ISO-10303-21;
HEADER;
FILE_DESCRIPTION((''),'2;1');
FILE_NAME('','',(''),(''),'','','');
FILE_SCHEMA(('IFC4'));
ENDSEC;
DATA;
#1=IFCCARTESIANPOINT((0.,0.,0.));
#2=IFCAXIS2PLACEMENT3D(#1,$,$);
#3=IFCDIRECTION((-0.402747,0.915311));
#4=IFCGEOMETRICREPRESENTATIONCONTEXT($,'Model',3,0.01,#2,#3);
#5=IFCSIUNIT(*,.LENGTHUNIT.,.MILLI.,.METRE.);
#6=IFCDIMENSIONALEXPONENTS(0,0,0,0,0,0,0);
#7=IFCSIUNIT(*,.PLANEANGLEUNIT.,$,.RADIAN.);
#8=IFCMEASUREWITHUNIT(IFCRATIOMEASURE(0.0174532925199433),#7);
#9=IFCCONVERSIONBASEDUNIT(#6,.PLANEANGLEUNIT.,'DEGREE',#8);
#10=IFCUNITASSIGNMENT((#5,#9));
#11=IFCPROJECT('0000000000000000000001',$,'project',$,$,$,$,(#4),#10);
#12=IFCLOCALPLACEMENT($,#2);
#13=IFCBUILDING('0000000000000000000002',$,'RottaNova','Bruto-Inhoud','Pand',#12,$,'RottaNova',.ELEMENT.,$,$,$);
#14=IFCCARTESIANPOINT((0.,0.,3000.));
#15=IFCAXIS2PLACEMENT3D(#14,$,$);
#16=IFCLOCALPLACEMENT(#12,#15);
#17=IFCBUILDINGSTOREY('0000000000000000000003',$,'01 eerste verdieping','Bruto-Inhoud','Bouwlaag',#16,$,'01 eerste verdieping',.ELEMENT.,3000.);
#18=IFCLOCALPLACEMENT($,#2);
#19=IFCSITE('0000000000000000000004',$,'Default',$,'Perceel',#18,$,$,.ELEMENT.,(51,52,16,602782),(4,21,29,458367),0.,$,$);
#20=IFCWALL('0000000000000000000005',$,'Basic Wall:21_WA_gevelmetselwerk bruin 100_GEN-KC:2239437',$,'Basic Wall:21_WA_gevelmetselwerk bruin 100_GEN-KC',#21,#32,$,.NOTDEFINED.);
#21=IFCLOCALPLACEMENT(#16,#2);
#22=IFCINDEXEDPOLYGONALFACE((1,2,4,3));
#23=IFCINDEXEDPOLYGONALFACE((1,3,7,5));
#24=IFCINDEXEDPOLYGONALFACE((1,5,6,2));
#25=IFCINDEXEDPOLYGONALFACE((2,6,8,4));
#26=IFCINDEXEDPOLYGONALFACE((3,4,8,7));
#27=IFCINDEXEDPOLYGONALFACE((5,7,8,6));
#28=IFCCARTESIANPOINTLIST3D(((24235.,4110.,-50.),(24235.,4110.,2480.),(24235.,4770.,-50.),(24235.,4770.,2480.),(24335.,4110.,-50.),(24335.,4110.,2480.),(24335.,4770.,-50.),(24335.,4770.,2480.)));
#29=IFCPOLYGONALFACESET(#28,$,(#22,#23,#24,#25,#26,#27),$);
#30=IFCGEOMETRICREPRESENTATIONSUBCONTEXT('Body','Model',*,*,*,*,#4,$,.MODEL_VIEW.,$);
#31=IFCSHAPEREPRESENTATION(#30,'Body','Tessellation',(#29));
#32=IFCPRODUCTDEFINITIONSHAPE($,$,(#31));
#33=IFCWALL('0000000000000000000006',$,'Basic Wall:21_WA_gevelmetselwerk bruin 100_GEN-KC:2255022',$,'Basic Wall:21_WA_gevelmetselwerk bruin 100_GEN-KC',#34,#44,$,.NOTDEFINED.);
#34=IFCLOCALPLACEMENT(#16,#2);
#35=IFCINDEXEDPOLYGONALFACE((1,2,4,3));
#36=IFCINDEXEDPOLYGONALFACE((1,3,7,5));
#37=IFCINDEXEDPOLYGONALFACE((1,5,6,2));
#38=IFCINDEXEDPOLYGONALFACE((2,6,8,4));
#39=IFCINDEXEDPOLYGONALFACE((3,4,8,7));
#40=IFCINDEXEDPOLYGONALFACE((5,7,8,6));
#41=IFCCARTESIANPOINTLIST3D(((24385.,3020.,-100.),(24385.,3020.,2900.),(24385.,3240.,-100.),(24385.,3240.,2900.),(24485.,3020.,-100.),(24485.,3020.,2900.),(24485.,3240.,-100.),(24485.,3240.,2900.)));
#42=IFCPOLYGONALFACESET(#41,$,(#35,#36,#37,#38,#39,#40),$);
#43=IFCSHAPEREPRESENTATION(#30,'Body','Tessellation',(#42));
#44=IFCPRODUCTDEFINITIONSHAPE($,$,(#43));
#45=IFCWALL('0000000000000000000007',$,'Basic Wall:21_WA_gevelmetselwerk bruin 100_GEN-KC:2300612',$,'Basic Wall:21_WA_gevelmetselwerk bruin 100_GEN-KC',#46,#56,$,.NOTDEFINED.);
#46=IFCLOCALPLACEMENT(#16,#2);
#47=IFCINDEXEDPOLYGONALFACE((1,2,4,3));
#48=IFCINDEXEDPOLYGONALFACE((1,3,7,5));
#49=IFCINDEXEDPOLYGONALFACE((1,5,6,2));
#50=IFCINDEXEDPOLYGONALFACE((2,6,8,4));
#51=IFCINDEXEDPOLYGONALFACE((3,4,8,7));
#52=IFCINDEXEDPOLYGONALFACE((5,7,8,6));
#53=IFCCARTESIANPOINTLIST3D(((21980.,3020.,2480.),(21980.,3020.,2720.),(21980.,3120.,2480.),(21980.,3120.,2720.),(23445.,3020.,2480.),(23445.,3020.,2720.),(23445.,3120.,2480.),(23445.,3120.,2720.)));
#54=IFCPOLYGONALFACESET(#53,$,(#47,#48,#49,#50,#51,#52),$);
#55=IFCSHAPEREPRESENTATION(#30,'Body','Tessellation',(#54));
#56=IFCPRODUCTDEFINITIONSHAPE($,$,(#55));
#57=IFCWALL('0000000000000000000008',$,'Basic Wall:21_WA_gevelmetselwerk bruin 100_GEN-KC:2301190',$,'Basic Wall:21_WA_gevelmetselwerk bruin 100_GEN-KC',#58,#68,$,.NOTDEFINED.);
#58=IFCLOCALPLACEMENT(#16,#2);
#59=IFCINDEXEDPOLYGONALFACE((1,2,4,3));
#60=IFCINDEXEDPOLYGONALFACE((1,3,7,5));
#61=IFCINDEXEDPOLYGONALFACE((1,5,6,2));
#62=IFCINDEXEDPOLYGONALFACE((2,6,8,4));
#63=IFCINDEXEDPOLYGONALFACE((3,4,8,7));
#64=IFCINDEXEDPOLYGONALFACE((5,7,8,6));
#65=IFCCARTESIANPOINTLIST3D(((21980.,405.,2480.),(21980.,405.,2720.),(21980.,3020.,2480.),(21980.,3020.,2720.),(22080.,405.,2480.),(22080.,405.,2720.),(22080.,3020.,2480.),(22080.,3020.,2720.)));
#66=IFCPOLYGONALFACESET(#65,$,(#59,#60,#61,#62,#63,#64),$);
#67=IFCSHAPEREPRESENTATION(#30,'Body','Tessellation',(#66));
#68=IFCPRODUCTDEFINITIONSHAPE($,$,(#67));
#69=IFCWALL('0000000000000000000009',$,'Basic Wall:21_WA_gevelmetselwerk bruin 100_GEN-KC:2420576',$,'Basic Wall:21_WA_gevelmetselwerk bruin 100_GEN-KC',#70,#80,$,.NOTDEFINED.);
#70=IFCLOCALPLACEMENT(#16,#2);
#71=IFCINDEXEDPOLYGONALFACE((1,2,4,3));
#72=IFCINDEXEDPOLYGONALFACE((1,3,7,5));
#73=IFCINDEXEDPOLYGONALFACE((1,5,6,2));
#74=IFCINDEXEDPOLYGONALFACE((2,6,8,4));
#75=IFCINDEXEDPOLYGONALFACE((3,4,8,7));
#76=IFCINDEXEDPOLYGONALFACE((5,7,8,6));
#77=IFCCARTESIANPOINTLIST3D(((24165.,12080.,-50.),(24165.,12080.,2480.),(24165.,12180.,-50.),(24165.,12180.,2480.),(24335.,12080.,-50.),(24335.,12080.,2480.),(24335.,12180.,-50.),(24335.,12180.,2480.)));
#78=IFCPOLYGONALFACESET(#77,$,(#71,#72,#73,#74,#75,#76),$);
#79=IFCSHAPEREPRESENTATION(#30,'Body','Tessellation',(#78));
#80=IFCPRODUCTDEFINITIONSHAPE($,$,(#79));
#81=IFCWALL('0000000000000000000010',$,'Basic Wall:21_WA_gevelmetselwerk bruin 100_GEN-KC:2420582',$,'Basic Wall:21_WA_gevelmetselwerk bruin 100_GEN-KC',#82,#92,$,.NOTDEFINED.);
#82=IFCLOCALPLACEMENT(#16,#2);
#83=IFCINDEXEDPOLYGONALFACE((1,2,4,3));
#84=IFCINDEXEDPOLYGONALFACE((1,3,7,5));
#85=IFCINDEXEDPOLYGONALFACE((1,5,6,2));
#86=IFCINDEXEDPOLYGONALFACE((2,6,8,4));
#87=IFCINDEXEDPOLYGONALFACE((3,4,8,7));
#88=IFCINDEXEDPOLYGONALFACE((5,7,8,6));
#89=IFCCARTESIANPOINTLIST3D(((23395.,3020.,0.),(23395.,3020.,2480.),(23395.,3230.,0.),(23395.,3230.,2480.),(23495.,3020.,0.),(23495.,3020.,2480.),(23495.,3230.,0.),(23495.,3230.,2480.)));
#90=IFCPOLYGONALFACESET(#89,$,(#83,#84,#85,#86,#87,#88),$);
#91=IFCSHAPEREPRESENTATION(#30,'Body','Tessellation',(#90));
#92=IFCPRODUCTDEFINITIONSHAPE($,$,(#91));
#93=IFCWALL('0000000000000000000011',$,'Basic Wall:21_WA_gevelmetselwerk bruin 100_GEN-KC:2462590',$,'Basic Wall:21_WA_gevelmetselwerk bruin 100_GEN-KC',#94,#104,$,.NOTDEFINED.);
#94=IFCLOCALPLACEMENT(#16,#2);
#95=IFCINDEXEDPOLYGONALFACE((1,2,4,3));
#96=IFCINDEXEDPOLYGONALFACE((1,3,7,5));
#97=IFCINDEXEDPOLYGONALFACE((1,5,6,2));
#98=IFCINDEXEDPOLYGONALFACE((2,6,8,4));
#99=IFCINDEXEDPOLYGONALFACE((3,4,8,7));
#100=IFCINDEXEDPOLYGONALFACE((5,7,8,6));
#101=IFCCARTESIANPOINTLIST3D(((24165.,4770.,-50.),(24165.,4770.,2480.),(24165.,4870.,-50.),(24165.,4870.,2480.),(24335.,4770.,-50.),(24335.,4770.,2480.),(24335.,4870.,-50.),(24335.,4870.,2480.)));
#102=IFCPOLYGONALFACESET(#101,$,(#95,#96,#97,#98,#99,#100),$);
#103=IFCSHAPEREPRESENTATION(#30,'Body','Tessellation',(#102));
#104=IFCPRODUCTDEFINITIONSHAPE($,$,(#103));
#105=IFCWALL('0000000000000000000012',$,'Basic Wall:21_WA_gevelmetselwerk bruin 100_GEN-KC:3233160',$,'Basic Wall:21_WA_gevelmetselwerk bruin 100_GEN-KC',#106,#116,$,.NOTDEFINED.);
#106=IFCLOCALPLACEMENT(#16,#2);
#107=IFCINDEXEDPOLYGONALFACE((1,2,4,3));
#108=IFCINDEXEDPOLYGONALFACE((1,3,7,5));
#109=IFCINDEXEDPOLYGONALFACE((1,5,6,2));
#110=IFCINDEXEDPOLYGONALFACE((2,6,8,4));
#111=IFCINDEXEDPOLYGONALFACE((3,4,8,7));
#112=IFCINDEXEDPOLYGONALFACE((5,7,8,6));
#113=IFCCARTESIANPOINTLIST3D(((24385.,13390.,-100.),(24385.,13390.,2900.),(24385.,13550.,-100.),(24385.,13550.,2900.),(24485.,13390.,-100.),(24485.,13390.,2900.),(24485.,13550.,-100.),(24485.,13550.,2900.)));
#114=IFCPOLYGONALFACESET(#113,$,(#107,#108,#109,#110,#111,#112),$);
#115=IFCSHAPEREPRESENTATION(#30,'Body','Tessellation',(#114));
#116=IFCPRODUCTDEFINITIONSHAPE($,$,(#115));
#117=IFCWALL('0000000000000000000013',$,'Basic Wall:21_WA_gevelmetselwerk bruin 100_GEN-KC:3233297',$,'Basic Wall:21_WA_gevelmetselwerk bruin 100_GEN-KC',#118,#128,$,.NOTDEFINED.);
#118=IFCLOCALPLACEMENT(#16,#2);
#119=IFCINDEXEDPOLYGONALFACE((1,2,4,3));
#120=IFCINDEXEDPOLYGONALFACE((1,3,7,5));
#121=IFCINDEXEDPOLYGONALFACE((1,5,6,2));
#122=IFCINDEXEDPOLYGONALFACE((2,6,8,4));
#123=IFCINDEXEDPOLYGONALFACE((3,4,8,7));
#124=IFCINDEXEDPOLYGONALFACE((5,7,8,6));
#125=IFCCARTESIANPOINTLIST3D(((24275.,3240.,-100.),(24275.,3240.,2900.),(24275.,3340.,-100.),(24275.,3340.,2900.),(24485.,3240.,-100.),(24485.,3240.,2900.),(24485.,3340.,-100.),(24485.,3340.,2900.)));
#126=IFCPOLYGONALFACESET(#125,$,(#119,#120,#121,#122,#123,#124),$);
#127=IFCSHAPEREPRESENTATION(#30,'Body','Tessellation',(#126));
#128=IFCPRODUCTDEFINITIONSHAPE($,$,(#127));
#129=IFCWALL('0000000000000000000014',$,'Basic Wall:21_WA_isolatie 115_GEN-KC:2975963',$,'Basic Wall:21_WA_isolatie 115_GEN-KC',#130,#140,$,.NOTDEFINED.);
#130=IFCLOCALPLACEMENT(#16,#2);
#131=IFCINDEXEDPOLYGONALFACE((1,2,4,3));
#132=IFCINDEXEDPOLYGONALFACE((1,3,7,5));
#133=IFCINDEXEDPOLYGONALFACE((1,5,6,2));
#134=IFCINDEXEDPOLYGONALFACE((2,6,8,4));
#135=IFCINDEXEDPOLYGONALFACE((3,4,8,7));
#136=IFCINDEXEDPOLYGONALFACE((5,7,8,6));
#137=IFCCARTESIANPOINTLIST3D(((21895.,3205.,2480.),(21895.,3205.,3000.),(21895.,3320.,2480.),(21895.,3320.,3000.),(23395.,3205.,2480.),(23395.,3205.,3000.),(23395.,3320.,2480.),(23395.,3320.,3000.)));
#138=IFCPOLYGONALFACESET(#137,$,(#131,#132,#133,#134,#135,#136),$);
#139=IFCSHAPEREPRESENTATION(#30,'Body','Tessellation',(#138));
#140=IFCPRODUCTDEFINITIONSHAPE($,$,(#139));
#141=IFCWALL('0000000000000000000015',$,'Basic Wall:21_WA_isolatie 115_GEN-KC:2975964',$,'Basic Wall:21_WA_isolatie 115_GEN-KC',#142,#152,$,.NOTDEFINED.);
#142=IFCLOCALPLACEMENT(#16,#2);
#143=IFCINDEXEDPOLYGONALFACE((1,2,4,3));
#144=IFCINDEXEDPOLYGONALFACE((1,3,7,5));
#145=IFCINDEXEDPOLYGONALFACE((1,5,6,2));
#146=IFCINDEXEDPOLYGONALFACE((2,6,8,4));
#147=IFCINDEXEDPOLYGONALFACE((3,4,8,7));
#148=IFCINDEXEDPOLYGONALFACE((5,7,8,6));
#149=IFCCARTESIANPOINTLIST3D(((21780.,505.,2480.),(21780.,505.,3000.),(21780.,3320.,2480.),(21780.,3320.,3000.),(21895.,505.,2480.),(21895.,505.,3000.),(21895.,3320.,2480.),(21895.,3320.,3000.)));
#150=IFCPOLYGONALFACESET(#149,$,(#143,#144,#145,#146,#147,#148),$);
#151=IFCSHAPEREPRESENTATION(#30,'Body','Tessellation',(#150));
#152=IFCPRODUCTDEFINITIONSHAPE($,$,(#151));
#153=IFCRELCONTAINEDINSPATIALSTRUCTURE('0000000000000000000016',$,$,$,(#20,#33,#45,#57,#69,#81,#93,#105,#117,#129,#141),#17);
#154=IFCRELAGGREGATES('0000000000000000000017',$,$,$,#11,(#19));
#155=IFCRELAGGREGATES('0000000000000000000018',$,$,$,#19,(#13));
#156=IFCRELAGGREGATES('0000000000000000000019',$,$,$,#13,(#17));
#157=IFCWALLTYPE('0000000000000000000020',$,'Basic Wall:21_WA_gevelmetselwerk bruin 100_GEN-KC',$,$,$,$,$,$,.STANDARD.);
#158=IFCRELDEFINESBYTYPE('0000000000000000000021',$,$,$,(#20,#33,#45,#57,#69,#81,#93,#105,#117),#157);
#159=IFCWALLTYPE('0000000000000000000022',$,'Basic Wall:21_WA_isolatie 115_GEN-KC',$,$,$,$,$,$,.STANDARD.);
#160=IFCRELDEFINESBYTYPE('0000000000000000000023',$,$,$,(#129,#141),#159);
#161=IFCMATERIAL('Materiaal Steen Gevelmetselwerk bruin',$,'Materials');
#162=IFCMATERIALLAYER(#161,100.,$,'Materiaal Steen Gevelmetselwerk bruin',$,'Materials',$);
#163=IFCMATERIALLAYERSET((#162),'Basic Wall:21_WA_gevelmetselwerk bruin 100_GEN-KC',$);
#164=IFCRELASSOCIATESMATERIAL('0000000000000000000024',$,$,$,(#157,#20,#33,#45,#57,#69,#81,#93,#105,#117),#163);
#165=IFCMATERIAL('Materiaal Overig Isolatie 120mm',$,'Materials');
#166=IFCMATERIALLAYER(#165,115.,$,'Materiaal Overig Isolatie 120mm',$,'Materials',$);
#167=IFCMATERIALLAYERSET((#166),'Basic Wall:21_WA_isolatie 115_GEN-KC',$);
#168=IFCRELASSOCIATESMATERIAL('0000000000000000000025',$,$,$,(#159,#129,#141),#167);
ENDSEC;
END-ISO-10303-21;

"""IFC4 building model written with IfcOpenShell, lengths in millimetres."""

from ifc_helpers import new_model, entity, si_unit, converted_unit, direction, frame, frame_2d, origin, place, context, subcontext, project, spatial, rectangle, extrude, material, layer, layer_set, type_object, element, save


model = new_model("IFC4")

# Units and contexts
model_context = context("Model", 3, precision=0.01, world=origin(), true_north=direction((-0.402747, 0.915311)))
body_context = subcontext(model_context, "Body", "Model", "MODEL_VIEW")
ifc_project = project(units=[si_unit("LENGTHUNIT", "METRE", prefix="MILLI"), converted_unit("PLANEANGLEUNIT", "DEGREE", entity("IfcRatioMeasure", 0.0174532925199433), si_unit("PLANEANGLEUNIT", "RADIAN"), dimensions=[0, 0, 0, 0, 0, 0, 0])], contexts=[model_context])

# Site, building, storey
site_placement = place(None, origin())
site = spatial("IfcSite", under=ifc_project, at=site_placement, Name="Default", ObjectType="Perceel", CompositionType="ELEMENT", RefLatitude=(51, 52, 16, 602782), RefLongitude=(4, 21, 29, 458367), RefElevation=0.0)
building_placement = place(None, origin())
building = spatial("IfcBuilding", under=site, at=building_placement, Name="RottaNova", Description="Bruto-Inhoud", ObjectType="Pand", LongName="RottaNova", CompositionType="ELEMENT")
storey_placement = place(building_placement, frame((0.0, 0.0, 3000.0)))
storey = spatial("IfcBuildingStorey", under=building, at=storey_placement, Name="01 eerste verdieping", Description="Bruto-Inhoud", ObjectType="Bouwlaag", LongName="01 eerste verdieping", CompositionType="ELEMENT", Elevation=3000.0)

# Walls
ifc_material_1 = material(Name="Materiaal Steen Gevelmetselwerk bruin", Category="Materials")
ifc_layer_1 = layer(ifc_material_1, 100.0, Name="Materiaal Steen Gevelmetselwerk bruin", Category="Materials")
ifc_layer_set_1 = layer_set([ifc_layer_1], Name="Basic Wall:21_WA_gevelmetselwerk bruin 100_GEN-KC")
wall_type_1 = type_object("IfcWallType", Name="Basic Wall:21_WA_gevelmetselwerk bruin 100_GEN-KC", PredefinedType="STANDARD", material=ifc_layer_set_1)
wall_1_placement = place(storey_placement, frame((24285.0, 4110.0, -50.0), z_axis=(0.0, 0.0, 1.0), x_axis=(0.0, 1.0, 0.0)))
element("IfcWall", 1, at=wall_1_placement, inside=storey, type_object=wall_type_1, material=ifc_layer_set_1, Name="Basic Wall:21_WA_gevelmetselwerk bruin 100_GEN-KC:2239437", ObjectType="Basic Wall:21_WA_gevelmetselwerk bruin 100_GEN-KC", PredefinedType="NOTDEFINED", context=body_context, shape_type="SweptSolid", body=[
    extrude(rectangle(XDim=660.0, YDim=100.0, at=frame_2d((330.0, 0.0), x_axis=(-1.0, 0.0))), origin(), (0.0, 0.0, 1.0), 2530.0),
])
wall_2_placement = place(storey_placement, frame((24435.0, 3240.0, -100.0), z_axis=(0.0, 0.0, 1.0), x_axis=(0.0, -1.0, 0.0)))
element("IfcWall", 2, at=wall_2_placement, inside=storey, type_object=wall_type_1, material=ifc_layer_set_1, Name="Basic Wall:21_WA_gevelmetselwerk bruin 100_GEN-KC:2255022", ObjectType="Basic Wall:21_WA_gevelmetselwerk bruin 100_GEN-KC", PredefinedType="NOTDEFINED", context=body_context, shape_type="SweptSolid", body=[
    extrude(rectangle(XDim=220.0, YDim=100.0, at=frame_2d((110.0, 0.0), x_axis=(-1.0, 0.0))), origin(), (0.0, 0.0, 1.0), 3000.0),
])
wall_3_placement = place(storey_placement, frame((23445.0, 3070.0, 2480.0), z_axis=(0.0, 0.0, 1.0), x_axis=(-1.0, 0.0, 0.0)))
element("IfcWall", 3, at=wall_3_placement, inside=storey, type_object=wall_type_1, material=ifc_layer_set_1, Name="Basic Wall:21_WA_gevelmetselwerk bruin 100_GEN-KC:2300612", ObjectType="Basic Wall:21_WA_gevelmetselwerk bruin 100_GEN-KC", PredefinedType="NOTDEFINED", context=body_context, shape_type="SweptSolid", body=[
    extrude(rectangle(XDim=1465.0, YDim=100.0, at=frame_2d((732.5, 0.0), x_axis=(-1.0, 0.0))), origin(), (0.0, 0.0, 1.0), 240.0),
])
wall_4_placement = place(storey_placement, frame((22030.0, 3020.0, 2480.0), z_axis=(0.0, 0.0, 1.0), x_axis=(0.0, -1.0, 0.0)))
element("IfcWall", 4, at=wall_4_placement, inside=storey, type_object=wall_type_1, material=ifc_layer_set_1, Name="Basic Wall:21_WA_gevelmetselwerk bruin 100_GEN-KC:2301190", ObjectType="Basic Wall:21_WA_gevelmetselwerk bruin 100_GEN-KC", PredefinedType="NOTDEFINED", context=body_context, shape_type="SweptSolid", body=[
    extrude(rectangle(XDim=2615.0, YDim=100.0, at=frame_2d((1307.5, 0.0), x_axis=(-1.0, 0.0))), origin(), (0.0, 0.0, 1.0), 240.0),
])
wall_5_placement = place(storey_placement, frame((24335.0, 12130.0, -50.0), z_axis=(0.0, 0.0, 1.0), x_axis=(-1.0, 0.0, 0.0)))
element("IfcWall", 5, at=wall_5_placement, inside=storey, type_object=wall_type_1, material=ifc_layer_set_1, Name="Basic Wall:21_WA_gevelmetselwerk bruin 100_GEN-KC:2420576", ObjectType="Basic Wall:21_WA_gevelmetselwerk bruin 100_GEN-KC", PredefinedType="NOTDEFINED", context=body_context, shape_type="SweptSolid", body=[
    extrude(rectangle(XDim=170.0, YDim=100.0, at=frame_2d((85.0, 0.0), x_axis=(-1.0, 0.0))), origin(), (0.0, 0.0, 1.0), 2530.0),
])
wall_6_placement = place(storey_placement, frame((23445.0, 3230.0, 0.0), z_axis=(0.0, 0.0, 1.0), x_axis=(0.0, -1.0, 0.0)))
element("IfcWall", 6, at=wall_6_placement, inside=storey, type_object=wall_type_1, material=ifc_layer_set_1, Name="Basic Wall:21_WA_gevelmetselwerk bruin 100_GEN-KC:2420582", ObjectType="Basic Wall:21_WA_gevelmetselwerk bruin 100_GEN-KC", PredefinedType="NOTDEFINED", context=body_context, shape_type="SweptSolid", body=[
    extrude(rectangle(XDim=210.0, YDim=100.0, at=frame_2d((105.0, 0.0), x_axis=(-1.0, 0.0))), origin(), (0.0, 0.0, 1.0), 2480.0),
])
wall_7_placement = place(storey_placement, frame((24335.0, 4820.0, -50.0), z_axis=(0.0, 0.0, 1.0), x_axis=(-1.0, 0.0, 0.0)))
element("IfcWall", 7, at=wall_7_placement, inside=storey, type_object=wall_type_1, material=ifc_layer_set_1, Name="Basic Wall:21_WA_gevelmetselwerk bruin 100_GEN-KC:2462590", ObjectType="Basic Wall:21_WA_gevelmetselwerk bruin 100_GEN-KC", PredefinedType="NOTDEFINED", context=body_context, shape_type="SweptSolid", body=[
    extrude(rectangle(XDim=170.0, YDim=100.0, at=frame_2d((85.0, 0.0), x_axis=(-1.0, 0.0))), origin(), (0.0, 0.0, 1.0), 2530.0),
])
wall_8_placement = place(storey_placement, frame((24435.0, 13390.0, -100.0), z_axis=(0.0, 0.0, 1.0), x_axis=(0.0, 1.0, 0.0)))
element("IfcWall", 8, at=wall_8_placement, inside=storey, type_object=wall_type_1, material=ifc_layer_set_1, Name="Basic Wall:21_WA_gevelmetselwerk bruin 100_GEN-KC:3233160", ObjectType="Basic Wall:21_WA_gevelmetselwerk bruin 100_GEN-KC", PredefinedType="NOTDEFINED", context=body_context, shape_type="SweptSolid", body=[
    extrude(rectangle(XDim=160.0, YDim=100.0, at=frame_2d((80.0, 0.0), x_axis=(-1.0, 0.0))), origin(), (0.0, 0.0, 1.0), 3000.0),
])
wall_9_placement = place(storey_placement, frame((24485.0, 3290.0, -100.0), z_axis=(0.0, 0.0, 1.0), x_axis=(-1.0, 0.0, 0.0)))
element("IfcWall", 9, at=wall_9_placement, inside=storey, type_object=wall_type_1, material=ifc_layer_set_1, Name="Basic Wall:21_WA_gevelmetselwerk bruin 100_GEN-KC:3233297", ObjectType="Basic Wall:21_WA_gevelmetselwerk bruin 100_GEN-KC", PredefinedType="NOTDEFINED", context=body_context, shape_type="SweptSolid", body=[
    extrude(rectangle(XDim=210.0, YDim=100.0, at=frame_2d((105.0, 0.0), x_axis=(-1.0, 0.0))), origin(), (0.0, 0.0, 1.0), 3000.0),
])
ifc_material_2 = material(Name="Materiaal Overig Isolatie 120mm", Category="Materials")
ifc_layer_2 = layer(ifc_material_2, 115.0, Name="Materiaal Overig Isolatie 120mm", Category="Materials")
ifc_layer_set_2 = layer_set([ifc_layer_2], Name="Basic Wall:21_WA_isolatie 115_GEN-KC")
wall_type_2 = type_object("IfcWallType", Name="Basic Wall:21_WA_isolatie 115_GEN-KC", PredefinedType="STANDARD", material=ifc_layer_set_2)
wall_10_placement = place(storey_placement, frame((23395.0, 3262.5, 2480.0), z_axis=(0.0, 0.0, 1.0), x_axis=(-1.0, 0.0, 0.0)))
element("IfcWall", 10, at=wall_10_placement, inside=storey, type_object=wall_type_2, material=ifc_layer_set_2, Name="Basic Wall:21_WA_isolatie 115_GEN-KC:2975963", ObjectType="Basic Wall:21_WA_isolatie 115_GEN-KC", PredefinedType="NOTDEFINED", context=body_context, shape_type="SweptSolid", body=[
    extrude(rectangle(XDim=1500.0, YDim=115.0, at=frame_2d((750.0, 0.0), x_axis=(1.0, 0.0))), origin(), (0.0, 0.0, 1.0), 520.0),
])
wall_11_placement = place(storey_placement, frame((21837.5, 3320.0, 2480.0), z_axis=(0.0, 0.0, 1.0), x_axis=(0.0, -1.0, 0.0)))
element("IfcWall", 11, at=wall_11_placement, inside=storey, type_object=wall_type_2, material=ifc_layer_set_2, Name="Basic Wall:21_WA_isolatie 115_GEN-KC:2975964", ObjectType="Basic Wall:21_WA_isolatie 115_GEN-KC", PredefinedType="NOTDEFINED", context=body_context, shape_type="SweptSolid", body=[
    extrude(rectangle(XDim=2815.0, YDim=115.0, at=frame_2d((1407.5, 0.0), x_axis=(-1.0, 0.0))), origin(), (0.0, 0.0, 1.0), 520.0),
])

save(model, "model.ifc")
